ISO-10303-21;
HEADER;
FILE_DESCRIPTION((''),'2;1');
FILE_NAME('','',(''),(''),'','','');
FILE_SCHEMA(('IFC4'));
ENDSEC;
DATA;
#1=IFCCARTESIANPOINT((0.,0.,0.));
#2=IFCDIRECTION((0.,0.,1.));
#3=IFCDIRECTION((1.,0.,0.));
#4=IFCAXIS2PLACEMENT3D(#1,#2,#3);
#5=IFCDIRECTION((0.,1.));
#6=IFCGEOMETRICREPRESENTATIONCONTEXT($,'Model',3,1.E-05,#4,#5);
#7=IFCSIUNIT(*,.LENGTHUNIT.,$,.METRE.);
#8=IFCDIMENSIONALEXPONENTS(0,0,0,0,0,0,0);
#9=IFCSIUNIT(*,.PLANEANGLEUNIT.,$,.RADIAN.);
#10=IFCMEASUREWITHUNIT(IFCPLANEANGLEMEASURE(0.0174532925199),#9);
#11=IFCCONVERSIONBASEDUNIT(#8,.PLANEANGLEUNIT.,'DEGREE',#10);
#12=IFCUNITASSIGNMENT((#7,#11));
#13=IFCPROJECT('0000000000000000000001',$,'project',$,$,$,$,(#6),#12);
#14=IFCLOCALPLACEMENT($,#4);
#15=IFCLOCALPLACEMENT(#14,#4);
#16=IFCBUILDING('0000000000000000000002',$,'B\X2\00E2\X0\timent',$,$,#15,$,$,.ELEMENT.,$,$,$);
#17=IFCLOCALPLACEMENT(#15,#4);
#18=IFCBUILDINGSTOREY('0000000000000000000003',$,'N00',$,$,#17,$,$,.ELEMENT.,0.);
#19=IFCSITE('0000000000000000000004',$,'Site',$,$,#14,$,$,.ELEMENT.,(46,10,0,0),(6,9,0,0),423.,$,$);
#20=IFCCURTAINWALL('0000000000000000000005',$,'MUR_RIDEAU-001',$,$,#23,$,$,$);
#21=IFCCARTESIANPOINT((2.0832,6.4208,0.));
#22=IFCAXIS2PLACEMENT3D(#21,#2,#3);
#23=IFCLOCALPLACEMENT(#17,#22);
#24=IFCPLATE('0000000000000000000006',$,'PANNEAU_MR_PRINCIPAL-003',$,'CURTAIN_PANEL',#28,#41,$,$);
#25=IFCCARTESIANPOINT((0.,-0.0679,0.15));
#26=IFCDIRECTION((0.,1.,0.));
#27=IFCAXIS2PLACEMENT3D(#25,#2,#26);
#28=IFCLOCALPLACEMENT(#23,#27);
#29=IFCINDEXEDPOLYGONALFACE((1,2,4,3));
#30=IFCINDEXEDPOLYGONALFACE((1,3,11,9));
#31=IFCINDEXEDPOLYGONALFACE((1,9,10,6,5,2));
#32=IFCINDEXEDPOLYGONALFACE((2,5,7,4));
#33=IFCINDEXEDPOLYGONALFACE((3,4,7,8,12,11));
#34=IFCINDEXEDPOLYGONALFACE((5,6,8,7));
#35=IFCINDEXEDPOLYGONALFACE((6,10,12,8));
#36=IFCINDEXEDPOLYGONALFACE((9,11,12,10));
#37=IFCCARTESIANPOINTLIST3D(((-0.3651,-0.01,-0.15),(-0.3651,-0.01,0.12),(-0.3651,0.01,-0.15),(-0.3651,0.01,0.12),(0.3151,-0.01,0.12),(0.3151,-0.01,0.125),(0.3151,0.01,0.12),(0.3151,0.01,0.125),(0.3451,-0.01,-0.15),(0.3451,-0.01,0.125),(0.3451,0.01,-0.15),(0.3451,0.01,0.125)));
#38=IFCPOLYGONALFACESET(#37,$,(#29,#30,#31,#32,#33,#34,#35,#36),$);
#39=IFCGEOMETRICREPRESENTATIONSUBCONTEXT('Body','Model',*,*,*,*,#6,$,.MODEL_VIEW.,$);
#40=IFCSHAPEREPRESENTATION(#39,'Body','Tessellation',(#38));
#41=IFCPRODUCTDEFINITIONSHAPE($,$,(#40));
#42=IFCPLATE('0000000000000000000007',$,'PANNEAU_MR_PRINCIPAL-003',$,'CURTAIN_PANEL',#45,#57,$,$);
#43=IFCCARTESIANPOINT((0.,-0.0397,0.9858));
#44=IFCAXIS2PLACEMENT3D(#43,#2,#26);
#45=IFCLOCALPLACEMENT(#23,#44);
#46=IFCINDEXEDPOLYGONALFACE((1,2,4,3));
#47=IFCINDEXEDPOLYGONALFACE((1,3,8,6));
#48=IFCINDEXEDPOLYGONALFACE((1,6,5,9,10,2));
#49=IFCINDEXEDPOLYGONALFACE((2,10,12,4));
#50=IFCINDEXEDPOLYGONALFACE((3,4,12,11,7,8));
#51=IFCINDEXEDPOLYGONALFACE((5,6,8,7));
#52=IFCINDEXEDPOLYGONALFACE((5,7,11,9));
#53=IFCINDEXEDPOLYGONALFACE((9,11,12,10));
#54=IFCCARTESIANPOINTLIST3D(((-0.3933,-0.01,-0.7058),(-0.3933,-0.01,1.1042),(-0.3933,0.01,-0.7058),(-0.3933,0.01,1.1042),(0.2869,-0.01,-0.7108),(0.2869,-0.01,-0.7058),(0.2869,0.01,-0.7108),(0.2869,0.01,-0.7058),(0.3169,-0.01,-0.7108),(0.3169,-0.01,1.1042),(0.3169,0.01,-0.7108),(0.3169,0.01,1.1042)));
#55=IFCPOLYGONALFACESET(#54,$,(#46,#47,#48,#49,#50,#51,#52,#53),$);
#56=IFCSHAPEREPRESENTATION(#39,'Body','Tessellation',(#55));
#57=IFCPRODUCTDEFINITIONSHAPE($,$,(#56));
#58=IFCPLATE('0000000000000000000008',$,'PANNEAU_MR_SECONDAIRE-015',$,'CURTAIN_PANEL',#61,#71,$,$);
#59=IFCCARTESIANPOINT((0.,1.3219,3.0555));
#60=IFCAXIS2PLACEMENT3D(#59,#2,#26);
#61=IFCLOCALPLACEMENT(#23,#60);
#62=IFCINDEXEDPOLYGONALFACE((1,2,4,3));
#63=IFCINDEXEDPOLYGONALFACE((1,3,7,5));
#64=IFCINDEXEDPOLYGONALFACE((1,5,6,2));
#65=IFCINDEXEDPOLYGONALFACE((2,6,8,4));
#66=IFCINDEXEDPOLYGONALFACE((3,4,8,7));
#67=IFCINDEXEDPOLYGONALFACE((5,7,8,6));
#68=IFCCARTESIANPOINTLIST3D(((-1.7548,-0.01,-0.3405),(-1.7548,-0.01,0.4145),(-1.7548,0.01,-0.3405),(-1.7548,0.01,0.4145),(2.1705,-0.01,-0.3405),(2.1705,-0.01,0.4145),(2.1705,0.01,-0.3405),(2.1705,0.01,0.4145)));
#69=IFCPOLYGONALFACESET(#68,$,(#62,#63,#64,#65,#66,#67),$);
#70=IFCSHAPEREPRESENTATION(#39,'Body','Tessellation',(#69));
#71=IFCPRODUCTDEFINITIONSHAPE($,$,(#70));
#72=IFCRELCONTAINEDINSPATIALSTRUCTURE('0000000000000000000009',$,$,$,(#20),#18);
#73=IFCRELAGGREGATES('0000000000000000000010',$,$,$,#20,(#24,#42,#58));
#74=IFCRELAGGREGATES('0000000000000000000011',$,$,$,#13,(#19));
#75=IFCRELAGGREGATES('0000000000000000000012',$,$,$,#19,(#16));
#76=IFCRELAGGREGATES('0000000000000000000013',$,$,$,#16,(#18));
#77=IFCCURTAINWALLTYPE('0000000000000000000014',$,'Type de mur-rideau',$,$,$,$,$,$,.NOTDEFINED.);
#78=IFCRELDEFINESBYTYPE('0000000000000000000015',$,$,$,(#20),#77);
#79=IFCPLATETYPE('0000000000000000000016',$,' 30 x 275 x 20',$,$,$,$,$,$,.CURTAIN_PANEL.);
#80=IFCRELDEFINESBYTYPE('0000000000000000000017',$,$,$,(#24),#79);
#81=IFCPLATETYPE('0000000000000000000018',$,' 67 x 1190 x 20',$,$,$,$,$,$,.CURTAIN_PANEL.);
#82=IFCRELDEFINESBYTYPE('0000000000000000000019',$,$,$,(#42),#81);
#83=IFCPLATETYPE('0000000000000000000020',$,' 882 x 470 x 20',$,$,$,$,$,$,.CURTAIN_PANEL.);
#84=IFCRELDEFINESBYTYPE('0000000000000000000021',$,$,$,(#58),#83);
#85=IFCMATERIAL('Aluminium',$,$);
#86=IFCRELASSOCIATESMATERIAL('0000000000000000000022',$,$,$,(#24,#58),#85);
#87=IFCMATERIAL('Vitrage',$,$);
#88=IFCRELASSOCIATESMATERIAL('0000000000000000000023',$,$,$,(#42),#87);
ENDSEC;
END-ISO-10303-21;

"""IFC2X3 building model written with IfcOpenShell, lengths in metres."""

from ifc_helpers import new_model, entity, si_unit, converted_unit, direction, frame, origin_with_axes, place, context, subcontext, project, spatial, polyline, outline, extrude, material, type_object, element, aggregate, save


model = new_model("IFC2X3")

# Units and contexts
model_context = context("Model", 3, precision=1e-05, world=origin_with_axes(), true_north=direction((0.0, 1.0)))
body_context = subcontext(model_context, "Body", "Model", "MODEL_VIEW")
ifc_project = project(units=[si_unit("LENGTHUNIT", "METRE"), converted_unit("PLANEANGLEUNIT", "DEGREE", entity("IfcPlaneAngleMeasure", 0.0174532925199), si_unit("PLANEANGLEUNIT", "RADIAN"), dimensions=[0, 0, 0, 0, 0, 0, 0])], contexts=[model_context])

# Site, building, storey
site_placement = place(None, origin_with_axes())
site = spatial("IfcSite", under=ifc_project, at=site_placement, Name="Site", CompositionType="ELEMENT", RefLatitude=(46, 10, 0, 0), RefLongitude=(6, 9, 0, 0), RefElevation=423.0)
building_placement = place(site_placement, origin_with_axes())
building = spatial("IfcBuilding", under=site, at=building_placement, Name="Bâtiment", CompositionType="ELEMENT")
storey_placement = place(building_placement, origin_with_axes())
storey = spatial("IfcBuildingStorey", under=building, at=storey_placement, Name="N00", CompositionType="ELEMENT", Elevation=0.0)

# Curtain wall, plates
curtain_wall_type = type_object("IfcCurtainWallType", Name="Type de mur-rideau", PredefinedType="NOTDEFINED")
curtain_wall_placement = place(storey_placement, frame((2.0832, 6.4208, 0.0), z_axis=(0.0, 0.0, 1.0), x_axis=(1.0, 0.0, 0.0)))
curtain_wall = element("IfcCurtainWall", 1, at=curtain_wall_placement, inside=storey, type_object=curtain_wall_type, Name="MUR_RIDEAU-001")
ifc_material_1 = material(Name="Aluminium")
ifc_material_2 = material(Name="Vitrage")
plate_type_1 = type_object("IfcPlateType", Name=" 30 x 275 x 20", PredefinedType="CURTAIN_PANEL")
plate_1_placement = place(curtain_wall_placement, frame((0.0, -0.0679, 0.15), z_axis=(0.0, 0.0, 1.0), x_axis=(0.0, 1.0, 0.0)))
plate_1 = element("IfcPlate", 2, at=plate_1_placement, type_object=plate_type_1, material=ifc_material_1, Name="PANNEAU_MR_PRINCIPAL-003", ObjectType="CURTAIN_PANEL", context=body_context, shape_type="SweptSolid", body=[
    extrude(outline(polyline([(0.3151, -0.125), (0.3451, -0.125), (0.3451, 0.15), (-0.3651, 0.15), (-0.3651, -0.12), (0.3151, -0.12), (0.3151, -0.125)])), frame((0.0, -0.01, 0.0), z_axis=(0.0, 1.0, 0.0), x_axis=(1.0, 0.0, 0.0)), (0.0, 0.0, 1.0), 0.02),
])
plate_type_2 = type_object("IfcPlateType", Name=" 67 x 1190 x 20", PredefinedType="CURTAIN_PANEL")
plate_2_placement = place(curtain_wall_placement, frame((0.0, -0.0397, 0.9858), z_axis=(0.0, 0.0, 1.0), x_axis=(0.0, 1.0, 0.0)))
plate_2 = element("IfcPlate", 3, at=plate_2_placement, type_object=plate_type_2, material=ifc_material_2, Name="PANNEAU_MR_PRINCIPAL-003", ObjectType="CURTAIN_PANEL", context=body_context, shape_type="SweptSolid", body=[
    extrude(outline(polyline([(-0.3933, -1.1042), (0.3169, -1.1042), (0.3169, 0.7108), (0.2869, 0.7108), (0.2869, 0.7058), (-0.3933, 0.7058), (-0.3933, -1.1042)])), frame((0.0, -0.01, 0.0), z_axis=(0.0, 1.0, 0.0), x_axis=(1.0, 0.0, 0.0)), (0.0, 0.0, 1.0), 0.02),
])
plate_type_3 = type_object("IfcPlateType", Name=" 882 x 470 x 20", PredefinedType="CURTAIN_PANEL")
plate_3_placement = place(curtain_wall_placement, frame((0.0, 1.3219, 3.0555), z_axis=(0.0, 0.0, 1.0), x_axis=(0.0, 1.0, 0.0)))
plate_3 = element("IfcPlate", 4, at=plate_3_placement, type_object=plate_type_3, material=ifc_material_1, Name="PANNEAU_MR_SECONDAIRE-015", ObjectType="CURTAIN_PANEL", context=body_context, shape_type="SweptSolid", body=[
    extrude(outline(polyline([(-1.7548, -0.4145), (2.1705, -0.4145), (2.1705, 0.3405), (-1.7548, 0.3405), (-1.7548, -0.4145)])), frame((0.0, -0.01, 0.0), z_axis=(0.0, 1.0, 0.0), x_axis=(1.0, 0.0, 0.0)), (0.0, 0.0, 1.0), 0.02),
])
aggregate(curtain_wall, [plate_1, plate_2, plate_3])

save(model, "model.ifc")
